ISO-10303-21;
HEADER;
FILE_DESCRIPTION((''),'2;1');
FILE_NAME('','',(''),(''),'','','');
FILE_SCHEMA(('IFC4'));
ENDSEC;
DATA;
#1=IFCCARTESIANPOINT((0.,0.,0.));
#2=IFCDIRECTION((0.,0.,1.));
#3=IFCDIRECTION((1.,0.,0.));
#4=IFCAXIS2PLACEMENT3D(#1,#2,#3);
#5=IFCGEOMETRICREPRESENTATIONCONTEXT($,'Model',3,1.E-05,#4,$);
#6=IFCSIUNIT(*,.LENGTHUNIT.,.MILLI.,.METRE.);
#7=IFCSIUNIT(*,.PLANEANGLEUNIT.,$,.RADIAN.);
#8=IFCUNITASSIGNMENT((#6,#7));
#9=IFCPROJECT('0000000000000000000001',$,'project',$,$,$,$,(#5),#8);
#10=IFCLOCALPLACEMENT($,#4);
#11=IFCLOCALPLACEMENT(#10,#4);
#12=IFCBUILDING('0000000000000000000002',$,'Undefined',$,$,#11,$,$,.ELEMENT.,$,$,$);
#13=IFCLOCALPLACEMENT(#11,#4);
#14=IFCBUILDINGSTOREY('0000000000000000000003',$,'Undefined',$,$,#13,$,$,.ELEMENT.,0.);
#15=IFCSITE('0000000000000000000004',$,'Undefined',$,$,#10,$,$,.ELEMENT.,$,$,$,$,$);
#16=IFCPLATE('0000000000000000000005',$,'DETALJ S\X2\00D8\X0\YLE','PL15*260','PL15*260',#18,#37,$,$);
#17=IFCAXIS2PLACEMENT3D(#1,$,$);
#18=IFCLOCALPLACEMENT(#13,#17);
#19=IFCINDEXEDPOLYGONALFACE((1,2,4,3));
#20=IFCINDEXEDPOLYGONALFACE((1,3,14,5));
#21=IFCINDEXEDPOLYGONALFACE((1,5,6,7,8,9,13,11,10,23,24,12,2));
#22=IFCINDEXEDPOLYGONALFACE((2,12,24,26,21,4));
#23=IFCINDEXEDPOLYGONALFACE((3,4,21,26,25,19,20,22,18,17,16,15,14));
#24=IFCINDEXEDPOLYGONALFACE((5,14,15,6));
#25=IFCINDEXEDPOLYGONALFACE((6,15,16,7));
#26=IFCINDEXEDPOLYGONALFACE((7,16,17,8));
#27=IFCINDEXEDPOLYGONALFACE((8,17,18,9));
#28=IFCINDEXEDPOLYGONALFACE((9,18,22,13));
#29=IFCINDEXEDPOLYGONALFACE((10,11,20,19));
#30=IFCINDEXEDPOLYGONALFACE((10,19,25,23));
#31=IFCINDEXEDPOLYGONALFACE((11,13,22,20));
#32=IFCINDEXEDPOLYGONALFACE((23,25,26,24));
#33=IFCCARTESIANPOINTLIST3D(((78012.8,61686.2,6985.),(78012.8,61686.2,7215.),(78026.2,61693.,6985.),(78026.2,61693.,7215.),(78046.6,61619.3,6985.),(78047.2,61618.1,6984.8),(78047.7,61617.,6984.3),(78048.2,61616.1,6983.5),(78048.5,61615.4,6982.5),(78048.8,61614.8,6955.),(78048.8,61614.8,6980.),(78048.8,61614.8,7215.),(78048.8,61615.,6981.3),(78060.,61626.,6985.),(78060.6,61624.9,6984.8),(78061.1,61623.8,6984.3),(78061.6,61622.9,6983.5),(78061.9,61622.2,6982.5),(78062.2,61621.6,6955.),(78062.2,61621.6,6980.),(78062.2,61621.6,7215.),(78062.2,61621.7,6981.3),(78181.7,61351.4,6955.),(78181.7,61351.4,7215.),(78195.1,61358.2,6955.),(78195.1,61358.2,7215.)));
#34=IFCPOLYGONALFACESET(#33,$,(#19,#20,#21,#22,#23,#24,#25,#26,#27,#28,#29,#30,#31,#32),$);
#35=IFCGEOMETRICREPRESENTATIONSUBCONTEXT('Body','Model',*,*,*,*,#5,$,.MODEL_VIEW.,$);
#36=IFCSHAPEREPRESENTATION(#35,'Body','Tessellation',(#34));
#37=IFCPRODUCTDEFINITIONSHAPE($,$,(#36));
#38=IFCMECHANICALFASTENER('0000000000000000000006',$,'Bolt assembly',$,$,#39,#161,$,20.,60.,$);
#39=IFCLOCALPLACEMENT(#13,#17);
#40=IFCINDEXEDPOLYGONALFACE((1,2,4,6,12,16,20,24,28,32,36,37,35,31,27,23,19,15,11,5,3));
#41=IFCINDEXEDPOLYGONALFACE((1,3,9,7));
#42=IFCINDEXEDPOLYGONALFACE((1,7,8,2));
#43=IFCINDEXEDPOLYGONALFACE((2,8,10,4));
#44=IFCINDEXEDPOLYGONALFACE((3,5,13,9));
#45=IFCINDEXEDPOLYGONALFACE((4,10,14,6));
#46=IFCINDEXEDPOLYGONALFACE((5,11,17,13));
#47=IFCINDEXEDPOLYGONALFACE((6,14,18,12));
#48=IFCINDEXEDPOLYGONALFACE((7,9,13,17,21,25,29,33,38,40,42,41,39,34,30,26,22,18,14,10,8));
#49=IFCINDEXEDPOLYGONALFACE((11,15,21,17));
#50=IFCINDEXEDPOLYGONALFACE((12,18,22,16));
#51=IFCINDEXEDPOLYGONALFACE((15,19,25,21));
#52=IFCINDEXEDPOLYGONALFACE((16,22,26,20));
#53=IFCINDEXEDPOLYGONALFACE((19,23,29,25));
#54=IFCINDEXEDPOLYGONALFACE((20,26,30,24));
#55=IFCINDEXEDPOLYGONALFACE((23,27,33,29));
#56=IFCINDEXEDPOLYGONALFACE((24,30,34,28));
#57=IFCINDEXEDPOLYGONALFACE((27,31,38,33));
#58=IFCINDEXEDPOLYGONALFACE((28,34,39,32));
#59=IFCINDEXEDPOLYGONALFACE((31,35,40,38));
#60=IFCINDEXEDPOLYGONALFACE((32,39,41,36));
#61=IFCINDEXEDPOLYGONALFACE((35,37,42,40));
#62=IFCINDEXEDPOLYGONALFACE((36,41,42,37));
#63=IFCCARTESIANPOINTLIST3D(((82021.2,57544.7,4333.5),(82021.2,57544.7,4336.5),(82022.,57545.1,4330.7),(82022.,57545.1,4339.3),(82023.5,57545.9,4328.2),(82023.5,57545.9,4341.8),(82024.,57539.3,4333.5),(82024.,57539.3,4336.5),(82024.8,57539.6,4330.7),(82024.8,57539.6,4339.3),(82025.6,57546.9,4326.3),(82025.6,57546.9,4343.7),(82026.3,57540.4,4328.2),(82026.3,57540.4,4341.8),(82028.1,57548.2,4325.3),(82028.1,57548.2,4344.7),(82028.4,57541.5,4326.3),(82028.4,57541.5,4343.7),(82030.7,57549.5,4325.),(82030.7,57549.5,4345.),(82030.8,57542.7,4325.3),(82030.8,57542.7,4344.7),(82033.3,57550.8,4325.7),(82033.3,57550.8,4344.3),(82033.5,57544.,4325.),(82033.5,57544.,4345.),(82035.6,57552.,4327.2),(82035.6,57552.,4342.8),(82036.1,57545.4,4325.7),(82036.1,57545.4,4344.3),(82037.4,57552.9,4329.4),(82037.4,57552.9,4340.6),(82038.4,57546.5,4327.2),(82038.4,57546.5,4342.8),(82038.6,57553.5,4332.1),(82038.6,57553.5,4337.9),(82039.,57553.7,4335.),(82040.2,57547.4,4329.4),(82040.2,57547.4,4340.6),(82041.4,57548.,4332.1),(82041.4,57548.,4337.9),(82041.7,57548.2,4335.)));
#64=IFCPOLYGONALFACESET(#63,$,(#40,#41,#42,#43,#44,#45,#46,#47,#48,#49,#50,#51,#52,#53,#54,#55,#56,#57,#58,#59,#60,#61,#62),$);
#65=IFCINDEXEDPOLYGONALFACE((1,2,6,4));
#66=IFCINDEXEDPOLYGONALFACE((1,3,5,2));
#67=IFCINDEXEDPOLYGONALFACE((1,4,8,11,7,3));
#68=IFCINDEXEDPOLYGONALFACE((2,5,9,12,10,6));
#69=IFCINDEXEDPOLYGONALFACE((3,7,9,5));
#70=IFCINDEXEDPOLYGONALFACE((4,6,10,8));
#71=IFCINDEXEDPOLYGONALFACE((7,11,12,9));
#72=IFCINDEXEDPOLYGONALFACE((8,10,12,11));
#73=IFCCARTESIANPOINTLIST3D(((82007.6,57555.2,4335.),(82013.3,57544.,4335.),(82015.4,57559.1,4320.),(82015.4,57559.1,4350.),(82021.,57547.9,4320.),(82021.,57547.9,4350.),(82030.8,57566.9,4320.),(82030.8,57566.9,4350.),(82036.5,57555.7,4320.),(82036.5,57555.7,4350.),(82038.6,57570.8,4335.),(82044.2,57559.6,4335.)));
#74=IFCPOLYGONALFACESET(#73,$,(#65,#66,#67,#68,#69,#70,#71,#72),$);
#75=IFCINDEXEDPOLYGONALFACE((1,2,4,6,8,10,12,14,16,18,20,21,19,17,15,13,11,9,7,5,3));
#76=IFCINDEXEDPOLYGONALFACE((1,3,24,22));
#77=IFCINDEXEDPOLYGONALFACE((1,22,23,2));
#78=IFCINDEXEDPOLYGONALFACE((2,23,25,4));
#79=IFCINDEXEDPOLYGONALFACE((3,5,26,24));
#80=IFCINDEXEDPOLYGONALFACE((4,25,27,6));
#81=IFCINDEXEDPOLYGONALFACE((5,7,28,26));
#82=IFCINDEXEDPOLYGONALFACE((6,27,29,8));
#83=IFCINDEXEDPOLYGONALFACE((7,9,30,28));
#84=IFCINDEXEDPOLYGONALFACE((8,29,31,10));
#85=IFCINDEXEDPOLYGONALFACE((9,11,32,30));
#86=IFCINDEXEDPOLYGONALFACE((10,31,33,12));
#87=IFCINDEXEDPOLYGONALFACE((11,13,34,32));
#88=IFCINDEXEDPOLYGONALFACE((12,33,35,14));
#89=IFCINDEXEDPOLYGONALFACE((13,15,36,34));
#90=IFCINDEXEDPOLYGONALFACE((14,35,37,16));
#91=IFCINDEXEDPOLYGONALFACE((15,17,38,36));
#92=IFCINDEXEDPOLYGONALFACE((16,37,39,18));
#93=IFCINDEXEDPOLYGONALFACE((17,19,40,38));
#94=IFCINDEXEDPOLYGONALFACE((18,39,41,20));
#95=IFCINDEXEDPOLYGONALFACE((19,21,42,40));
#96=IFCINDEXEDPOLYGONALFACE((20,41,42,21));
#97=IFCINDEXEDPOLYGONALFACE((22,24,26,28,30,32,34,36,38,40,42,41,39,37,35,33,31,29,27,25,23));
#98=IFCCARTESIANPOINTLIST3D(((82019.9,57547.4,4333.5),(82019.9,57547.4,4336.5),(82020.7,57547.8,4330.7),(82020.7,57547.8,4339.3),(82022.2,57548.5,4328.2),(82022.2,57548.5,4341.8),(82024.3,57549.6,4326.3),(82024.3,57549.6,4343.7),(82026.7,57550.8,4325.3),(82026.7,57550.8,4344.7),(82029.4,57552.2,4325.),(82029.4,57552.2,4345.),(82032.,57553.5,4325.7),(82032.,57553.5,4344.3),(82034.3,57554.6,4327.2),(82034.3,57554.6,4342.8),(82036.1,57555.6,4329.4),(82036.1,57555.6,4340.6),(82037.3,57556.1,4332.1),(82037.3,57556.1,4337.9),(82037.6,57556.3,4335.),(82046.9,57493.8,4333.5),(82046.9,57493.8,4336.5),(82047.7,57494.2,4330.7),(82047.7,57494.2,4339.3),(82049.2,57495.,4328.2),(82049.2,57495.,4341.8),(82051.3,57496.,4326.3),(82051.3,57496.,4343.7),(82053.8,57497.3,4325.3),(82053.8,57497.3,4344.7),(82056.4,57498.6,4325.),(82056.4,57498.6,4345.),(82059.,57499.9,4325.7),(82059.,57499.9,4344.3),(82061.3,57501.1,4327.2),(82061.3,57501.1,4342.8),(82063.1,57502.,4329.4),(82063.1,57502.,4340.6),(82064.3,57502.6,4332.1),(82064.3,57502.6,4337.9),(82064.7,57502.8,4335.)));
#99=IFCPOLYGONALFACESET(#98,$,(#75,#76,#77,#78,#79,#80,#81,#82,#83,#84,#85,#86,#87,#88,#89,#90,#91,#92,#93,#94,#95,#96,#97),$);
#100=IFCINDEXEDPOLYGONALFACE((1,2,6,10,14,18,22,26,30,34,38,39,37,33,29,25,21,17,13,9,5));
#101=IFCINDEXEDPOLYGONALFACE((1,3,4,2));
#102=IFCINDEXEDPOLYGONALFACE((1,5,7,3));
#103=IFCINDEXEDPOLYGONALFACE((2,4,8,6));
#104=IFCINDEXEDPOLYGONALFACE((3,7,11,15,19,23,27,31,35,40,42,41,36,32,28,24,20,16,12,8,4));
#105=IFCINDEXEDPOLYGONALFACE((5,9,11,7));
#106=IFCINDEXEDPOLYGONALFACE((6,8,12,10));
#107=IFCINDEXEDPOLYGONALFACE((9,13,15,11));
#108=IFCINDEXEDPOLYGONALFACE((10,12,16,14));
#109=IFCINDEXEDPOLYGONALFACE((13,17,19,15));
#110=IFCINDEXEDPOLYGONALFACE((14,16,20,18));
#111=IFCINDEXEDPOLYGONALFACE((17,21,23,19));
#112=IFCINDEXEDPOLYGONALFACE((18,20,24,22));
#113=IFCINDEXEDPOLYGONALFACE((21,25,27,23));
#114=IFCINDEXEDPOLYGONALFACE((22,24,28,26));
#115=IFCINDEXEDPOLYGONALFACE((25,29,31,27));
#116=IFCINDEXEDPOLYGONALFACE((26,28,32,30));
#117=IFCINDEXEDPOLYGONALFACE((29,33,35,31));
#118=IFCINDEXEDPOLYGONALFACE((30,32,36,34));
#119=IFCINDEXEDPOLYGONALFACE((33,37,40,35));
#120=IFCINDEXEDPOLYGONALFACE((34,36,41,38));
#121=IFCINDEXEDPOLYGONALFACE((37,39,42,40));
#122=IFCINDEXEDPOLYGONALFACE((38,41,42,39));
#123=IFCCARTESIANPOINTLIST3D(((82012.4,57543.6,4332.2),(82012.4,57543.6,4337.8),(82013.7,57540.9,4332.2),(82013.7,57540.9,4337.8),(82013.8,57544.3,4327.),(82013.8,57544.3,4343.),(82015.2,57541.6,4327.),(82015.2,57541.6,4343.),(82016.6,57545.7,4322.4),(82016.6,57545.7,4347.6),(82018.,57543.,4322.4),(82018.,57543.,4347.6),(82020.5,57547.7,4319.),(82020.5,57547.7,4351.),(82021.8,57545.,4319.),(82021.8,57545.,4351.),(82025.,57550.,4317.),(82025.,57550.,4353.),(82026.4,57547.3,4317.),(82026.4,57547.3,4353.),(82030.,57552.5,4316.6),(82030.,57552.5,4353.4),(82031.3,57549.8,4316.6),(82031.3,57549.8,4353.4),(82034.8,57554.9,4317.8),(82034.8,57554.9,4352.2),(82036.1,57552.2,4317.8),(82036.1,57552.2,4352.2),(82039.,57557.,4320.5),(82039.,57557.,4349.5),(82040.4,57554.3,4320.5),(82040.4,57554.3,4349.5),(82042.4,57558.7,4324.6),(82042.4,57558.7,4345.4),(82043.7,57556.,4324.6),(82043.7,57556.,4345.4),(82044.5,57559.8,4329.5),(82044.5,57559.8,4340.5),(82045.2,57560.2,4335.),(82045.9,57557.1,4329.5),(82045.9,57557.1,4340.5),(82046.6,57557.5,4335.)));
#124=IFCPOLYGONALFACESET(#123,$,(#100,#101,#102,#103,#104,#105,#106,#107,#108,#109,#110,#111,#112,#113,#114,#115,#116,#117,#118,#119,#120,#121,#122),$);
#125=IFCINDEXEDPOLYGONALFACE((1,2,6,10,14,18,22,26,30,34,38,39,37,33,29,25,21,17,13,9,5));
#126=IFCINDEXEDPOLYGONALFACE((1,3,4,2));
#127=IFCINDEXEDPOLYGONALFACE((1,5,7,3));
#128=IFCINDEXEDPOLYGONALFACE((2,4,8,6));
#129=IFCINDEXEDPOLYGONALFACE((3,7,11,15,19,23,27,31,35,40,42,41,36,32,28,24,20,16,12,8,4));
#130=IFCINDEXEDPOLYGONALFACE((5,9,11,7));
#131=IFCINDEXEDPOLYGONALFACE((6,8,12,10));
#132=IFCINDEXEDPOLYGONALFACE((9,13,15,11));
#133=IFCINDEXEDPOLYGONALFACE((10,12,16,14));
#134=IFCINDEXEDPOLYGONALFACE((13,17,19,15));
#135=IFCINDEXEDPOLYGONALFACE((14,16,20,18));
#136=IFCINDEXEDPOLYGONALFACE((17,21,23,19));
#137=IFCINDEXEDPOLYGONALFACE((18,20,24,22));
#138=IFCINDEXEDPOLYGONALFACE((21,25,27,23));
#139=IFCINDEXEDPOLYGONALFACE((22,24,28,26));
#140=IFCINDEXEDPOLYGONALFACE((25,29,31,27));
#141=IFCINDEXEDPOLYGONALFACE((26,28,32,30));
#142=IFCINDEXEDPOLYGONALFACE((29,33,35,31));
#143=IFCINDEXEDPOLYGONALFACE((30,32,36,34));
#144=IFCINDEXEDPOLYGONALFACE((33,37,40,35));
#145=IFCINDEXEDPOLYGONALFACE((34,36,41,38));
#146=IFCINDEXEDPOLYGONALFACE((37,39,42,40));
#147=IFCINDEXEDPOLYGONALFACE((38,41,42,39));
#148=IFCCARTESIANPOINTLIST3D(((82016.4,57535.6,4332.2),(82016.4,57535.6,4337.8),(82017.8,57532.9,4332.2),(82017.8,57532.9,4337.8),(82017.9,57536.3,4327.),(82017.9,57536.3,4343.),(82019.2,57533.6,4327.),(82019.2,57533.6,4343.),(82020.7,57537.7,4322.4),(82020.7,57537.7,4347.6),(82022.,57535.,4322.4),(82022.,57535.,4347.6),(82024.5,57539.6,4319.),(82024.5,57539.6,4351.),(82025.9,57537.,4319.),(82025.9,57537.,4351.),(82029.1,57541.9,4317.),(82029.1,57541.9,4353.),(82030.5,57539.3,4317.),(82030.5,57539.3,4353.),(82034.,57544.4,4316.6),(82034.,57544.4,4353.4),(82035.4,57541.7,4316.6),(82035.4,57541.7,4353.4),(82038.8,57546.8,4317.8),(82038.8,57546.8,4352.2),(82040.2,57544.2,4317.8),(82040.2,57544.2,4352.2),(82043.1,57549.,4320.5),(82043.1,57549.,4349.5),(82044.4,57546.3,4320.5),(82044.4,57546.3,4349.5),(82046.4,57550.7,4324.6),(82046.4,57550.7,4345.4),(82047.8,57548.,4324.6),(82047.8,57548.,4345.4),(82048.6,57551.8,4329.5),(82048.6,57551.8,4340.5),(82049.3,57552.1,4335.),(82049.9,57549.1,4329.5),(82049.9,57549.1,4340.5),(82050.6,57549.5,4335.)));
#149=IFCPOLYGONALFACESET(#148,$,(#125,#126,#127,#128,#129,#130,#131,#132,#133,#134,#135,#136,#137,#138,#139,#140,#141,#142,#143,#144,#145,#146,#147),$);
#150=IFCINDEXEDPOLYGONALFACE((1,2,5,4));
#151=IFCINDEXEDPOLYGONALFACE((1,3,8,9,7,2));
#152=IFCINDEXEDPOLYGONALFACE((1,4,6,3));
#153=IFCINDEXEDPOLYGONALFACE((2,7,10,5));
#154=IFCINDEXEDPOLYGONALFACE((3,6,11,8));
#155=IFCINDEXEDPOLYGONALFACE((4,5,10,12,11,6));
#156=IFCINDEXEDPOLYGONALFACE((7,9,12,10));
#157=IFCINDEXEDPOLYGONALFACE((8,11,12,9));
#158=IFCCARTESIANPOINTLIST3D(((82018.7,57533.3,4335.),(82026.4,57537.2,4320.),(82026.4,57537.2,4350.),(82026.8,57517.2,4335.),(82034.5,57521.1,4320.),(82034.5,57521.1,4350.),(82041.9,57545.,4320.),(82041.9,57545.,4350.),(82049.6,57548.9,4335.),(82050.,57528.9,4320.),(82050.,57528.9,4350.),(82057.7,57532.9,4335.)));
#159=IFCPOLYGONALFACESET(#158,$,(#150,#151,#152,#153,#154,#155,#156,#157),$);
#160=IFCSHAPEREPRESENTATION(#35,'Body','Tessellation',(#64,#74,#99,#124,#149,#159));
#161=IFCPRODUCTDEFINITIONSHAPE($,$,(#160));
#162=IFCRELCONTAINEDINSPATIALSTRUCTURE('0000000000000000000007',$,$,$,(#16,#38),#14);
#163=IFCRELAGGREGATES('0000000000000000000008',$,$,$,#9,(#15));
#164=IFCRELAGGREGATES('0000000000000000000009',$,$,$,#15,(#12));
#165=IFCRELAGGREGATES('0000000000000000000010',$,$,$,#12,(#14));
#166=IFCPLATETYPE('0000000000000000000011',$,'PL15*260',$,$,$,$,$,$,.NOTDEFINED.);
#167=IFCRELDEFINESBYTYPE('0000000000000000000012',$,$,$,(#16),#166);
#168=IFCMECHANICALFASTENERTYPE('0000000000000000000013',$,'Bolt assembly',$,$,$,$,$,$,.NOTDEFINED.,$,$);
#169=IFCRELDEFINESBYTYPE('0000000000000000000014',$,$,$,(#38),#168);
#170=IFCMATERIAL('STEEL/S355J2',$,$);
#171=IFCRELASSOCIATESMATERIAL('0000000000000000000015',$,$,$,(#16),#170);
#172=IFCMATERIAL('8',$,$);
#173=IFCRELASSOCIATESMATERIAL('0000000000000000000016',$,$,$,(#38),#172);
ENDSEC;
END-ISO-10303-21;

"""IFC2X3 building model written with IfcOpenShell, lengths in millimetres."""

from ifc_helpers import new_model, si_unit, frame, frame_2d, origin_with_axes, origin_2d_with_axis, place, context, subcontext, project, spatial, polyline, circle_curve, parameter, trimmed, segment, composite_curve, circle, outline, extrude, source, transform, mapped, material, type_object, element, save


model = new_model("IFC2X3")

# Units and contexts
model_context = context("Model", 3, precision=1e-05, world=origin_with_axes())
body_context = subcontext(model_context, "Body", "Model", "MODEL_VIEW")
ifc_project = project(units=[si_unit("LENGTHUNIT", "METRE", prefix="MILLI"), si_unit("PLANEANGLEUNIT", "RADIAN")], contexts=[model_context])

# Site, building, storey
site_placement = place(None, origin_with_axes())
site = spatial("IfcSite", under=ifc_project, at=site_placement, Name="Undefined", CompositionType="ELEMENT")
building_placement = place(site_placement, origin_with_axes())
building = spatial("IfcBuilding", under=site, at=building_placement, Name="Undefined", CompositionType="ELEMENT")
storey_placement = place(building_placement, origin_with_axes())
storey = spatial("IfcBuildingStorey", under=building, at=storey_placement, Name="Undefined", CompositionType="ELEMENT", Elevation=0.0)

# Shared definitions
ifc_material_1 = material(Name="STEEL/S355J2")

# Plate
plate_type_1 = type_object("IfcPlateType", Name="PL15*260", PredefinedType="NOTDEFINED")
plate_1_placement = place(storey_placement, frame((78055.5, 61618.2, 7215.0), z_axis=(0.892822, 0.45041, 0.0), x_axis=(0.45041, -0.892822, 0.0)))
element("IfcPlate", 1, at=plate_1_placement, inside=storey, type_object=plate_type_1, material=ifc_material_1, Name="DETALJ SØYLE", Description="PL15*260", ObjectType="PL15*260", context=body_context, shape_type="SweptSolid", body=[
    extrude(outline(composite_curve([segment(polyline([(0.0, 0.0), (295.0, 0.0), (295.0, 260.0), (0.0, 260.0), (0.0, 235.0)]), True, "CONTINUOUS"), segment(trimmed(circle_curve(frame_2d((-5.0, 235.0), x_axis=(1.0, 0.0)), 5.0), [parameter(0.0)], [parameter(4.712389)], False, "PARAMETER"), True, "CONTINUOUS"), segment(polyline([(-5.0, 230.0), (-80.0, 230.0), (-80.0, 0.0), (0.0, 0.0)]), True, "CONTINUOUS")], self_intersect=True)), frame((0.0, 0.0, -7.5), z_axis=(0.0, 0.0, 1.0), x_axis=(1.0, 0.0, 0.0)), (0.0, 0.0, 1.0), 15.0),
])

# Mechanical fastener
ifc_material_2 = material(Name="8")
mechanical_fastener_type = type_object("IfcMechanicalFastenerType", Name="Bolt assembly")
shared_shape_1 = source(origin_with_axes(), body_context, "Body", "SweptSolid", [
    extrude(circle(Radius=10.0, at=origin_2d_with_axis()), frame((0.0, 0.0, 0.0), z_axis=(0.0, 1.0, 0.0), x_axis=(1.0, 0.0, 0.0)), (0.0, 0.0, 1.0), 6.1),
    extrude(outline(polyline([(17.3, 0.0), (8.7, 15.0), (-8.7, 15.0), (-17.3, 0.0), (-8.7, -15.0), (8.7, -15.0), (17.3, 0.0)])), frame((0.0, -15.5, 0.0), z_axis=(0.0, 1.0, 0.0), x_axis=(1.0, 0.0, 0.0)), (0.0, 0.0, 1.0), 12.5),
    extrude(circle(Radius=10.0, at=origin_2d_with_axis()), frame((0.0, -3.0, 0.0), z_axis=(0.0, 1.0, 0.0), x_axis=(1.0, 0.0, 0.0)), (0.0, 0.0, 1.0), 60.0),
    extrude(circle(Radius=18.5, at=origin_2d_with_axis()), frame((0.0, -3.0, 0.0), z_axis=(0.0, 1.0, 0.0), x_axis=(1.0, 0.0, 0.0)), (0.0, 0.0, 1.0), 3.0),
    extrude(circle(Radius=18.5, at=origin_2d_with_axis()), frame((0.0, 6.0, 0.0), z_axis=(0.0, 1.0, 0.0), x_axis=(1.0, 0.0, 0.0)), (0.0, 0.0, 1.0), 3.0),
    extrude(outline(polyline([(17.3, 0.0), (8.7, 15.0), (-8.7, 15.0), (-17.3, 0.0), (-8.7, -15.0), (8.7, -15.0), (17.3, 0.0)])), frame((0.0, 9.0, 0.0), z_axis=(0.0, 1.0, 0.0), x_axis=(1.0, 0.0, 0.0)), (0.0, 0.0, 1.0), 18.0),
])
mechanical_fastener_1_placement = place(storey_placement, frame((82030.1, 57549.1, 4335.0), z_axis=(0.0, 0.0, -1.0), x_axis=(0.89277, 0.450512, 0.0)))
element("IfcMechanicalFastener", 2, at=mechanical_fastener_1_placement, inside=storey, type_object=mechanical_fastener_type, material=ifc_material_2, Name="Bolt assembly", NominalDiameter=20.0, NominalLength=60.0, context=body_context, shape_type="MappedRepresentation", body=[
    mapped(shared_shape_1, transform((0.0, 0.0, 0.0))),
])

save(model, "model.ifc")
